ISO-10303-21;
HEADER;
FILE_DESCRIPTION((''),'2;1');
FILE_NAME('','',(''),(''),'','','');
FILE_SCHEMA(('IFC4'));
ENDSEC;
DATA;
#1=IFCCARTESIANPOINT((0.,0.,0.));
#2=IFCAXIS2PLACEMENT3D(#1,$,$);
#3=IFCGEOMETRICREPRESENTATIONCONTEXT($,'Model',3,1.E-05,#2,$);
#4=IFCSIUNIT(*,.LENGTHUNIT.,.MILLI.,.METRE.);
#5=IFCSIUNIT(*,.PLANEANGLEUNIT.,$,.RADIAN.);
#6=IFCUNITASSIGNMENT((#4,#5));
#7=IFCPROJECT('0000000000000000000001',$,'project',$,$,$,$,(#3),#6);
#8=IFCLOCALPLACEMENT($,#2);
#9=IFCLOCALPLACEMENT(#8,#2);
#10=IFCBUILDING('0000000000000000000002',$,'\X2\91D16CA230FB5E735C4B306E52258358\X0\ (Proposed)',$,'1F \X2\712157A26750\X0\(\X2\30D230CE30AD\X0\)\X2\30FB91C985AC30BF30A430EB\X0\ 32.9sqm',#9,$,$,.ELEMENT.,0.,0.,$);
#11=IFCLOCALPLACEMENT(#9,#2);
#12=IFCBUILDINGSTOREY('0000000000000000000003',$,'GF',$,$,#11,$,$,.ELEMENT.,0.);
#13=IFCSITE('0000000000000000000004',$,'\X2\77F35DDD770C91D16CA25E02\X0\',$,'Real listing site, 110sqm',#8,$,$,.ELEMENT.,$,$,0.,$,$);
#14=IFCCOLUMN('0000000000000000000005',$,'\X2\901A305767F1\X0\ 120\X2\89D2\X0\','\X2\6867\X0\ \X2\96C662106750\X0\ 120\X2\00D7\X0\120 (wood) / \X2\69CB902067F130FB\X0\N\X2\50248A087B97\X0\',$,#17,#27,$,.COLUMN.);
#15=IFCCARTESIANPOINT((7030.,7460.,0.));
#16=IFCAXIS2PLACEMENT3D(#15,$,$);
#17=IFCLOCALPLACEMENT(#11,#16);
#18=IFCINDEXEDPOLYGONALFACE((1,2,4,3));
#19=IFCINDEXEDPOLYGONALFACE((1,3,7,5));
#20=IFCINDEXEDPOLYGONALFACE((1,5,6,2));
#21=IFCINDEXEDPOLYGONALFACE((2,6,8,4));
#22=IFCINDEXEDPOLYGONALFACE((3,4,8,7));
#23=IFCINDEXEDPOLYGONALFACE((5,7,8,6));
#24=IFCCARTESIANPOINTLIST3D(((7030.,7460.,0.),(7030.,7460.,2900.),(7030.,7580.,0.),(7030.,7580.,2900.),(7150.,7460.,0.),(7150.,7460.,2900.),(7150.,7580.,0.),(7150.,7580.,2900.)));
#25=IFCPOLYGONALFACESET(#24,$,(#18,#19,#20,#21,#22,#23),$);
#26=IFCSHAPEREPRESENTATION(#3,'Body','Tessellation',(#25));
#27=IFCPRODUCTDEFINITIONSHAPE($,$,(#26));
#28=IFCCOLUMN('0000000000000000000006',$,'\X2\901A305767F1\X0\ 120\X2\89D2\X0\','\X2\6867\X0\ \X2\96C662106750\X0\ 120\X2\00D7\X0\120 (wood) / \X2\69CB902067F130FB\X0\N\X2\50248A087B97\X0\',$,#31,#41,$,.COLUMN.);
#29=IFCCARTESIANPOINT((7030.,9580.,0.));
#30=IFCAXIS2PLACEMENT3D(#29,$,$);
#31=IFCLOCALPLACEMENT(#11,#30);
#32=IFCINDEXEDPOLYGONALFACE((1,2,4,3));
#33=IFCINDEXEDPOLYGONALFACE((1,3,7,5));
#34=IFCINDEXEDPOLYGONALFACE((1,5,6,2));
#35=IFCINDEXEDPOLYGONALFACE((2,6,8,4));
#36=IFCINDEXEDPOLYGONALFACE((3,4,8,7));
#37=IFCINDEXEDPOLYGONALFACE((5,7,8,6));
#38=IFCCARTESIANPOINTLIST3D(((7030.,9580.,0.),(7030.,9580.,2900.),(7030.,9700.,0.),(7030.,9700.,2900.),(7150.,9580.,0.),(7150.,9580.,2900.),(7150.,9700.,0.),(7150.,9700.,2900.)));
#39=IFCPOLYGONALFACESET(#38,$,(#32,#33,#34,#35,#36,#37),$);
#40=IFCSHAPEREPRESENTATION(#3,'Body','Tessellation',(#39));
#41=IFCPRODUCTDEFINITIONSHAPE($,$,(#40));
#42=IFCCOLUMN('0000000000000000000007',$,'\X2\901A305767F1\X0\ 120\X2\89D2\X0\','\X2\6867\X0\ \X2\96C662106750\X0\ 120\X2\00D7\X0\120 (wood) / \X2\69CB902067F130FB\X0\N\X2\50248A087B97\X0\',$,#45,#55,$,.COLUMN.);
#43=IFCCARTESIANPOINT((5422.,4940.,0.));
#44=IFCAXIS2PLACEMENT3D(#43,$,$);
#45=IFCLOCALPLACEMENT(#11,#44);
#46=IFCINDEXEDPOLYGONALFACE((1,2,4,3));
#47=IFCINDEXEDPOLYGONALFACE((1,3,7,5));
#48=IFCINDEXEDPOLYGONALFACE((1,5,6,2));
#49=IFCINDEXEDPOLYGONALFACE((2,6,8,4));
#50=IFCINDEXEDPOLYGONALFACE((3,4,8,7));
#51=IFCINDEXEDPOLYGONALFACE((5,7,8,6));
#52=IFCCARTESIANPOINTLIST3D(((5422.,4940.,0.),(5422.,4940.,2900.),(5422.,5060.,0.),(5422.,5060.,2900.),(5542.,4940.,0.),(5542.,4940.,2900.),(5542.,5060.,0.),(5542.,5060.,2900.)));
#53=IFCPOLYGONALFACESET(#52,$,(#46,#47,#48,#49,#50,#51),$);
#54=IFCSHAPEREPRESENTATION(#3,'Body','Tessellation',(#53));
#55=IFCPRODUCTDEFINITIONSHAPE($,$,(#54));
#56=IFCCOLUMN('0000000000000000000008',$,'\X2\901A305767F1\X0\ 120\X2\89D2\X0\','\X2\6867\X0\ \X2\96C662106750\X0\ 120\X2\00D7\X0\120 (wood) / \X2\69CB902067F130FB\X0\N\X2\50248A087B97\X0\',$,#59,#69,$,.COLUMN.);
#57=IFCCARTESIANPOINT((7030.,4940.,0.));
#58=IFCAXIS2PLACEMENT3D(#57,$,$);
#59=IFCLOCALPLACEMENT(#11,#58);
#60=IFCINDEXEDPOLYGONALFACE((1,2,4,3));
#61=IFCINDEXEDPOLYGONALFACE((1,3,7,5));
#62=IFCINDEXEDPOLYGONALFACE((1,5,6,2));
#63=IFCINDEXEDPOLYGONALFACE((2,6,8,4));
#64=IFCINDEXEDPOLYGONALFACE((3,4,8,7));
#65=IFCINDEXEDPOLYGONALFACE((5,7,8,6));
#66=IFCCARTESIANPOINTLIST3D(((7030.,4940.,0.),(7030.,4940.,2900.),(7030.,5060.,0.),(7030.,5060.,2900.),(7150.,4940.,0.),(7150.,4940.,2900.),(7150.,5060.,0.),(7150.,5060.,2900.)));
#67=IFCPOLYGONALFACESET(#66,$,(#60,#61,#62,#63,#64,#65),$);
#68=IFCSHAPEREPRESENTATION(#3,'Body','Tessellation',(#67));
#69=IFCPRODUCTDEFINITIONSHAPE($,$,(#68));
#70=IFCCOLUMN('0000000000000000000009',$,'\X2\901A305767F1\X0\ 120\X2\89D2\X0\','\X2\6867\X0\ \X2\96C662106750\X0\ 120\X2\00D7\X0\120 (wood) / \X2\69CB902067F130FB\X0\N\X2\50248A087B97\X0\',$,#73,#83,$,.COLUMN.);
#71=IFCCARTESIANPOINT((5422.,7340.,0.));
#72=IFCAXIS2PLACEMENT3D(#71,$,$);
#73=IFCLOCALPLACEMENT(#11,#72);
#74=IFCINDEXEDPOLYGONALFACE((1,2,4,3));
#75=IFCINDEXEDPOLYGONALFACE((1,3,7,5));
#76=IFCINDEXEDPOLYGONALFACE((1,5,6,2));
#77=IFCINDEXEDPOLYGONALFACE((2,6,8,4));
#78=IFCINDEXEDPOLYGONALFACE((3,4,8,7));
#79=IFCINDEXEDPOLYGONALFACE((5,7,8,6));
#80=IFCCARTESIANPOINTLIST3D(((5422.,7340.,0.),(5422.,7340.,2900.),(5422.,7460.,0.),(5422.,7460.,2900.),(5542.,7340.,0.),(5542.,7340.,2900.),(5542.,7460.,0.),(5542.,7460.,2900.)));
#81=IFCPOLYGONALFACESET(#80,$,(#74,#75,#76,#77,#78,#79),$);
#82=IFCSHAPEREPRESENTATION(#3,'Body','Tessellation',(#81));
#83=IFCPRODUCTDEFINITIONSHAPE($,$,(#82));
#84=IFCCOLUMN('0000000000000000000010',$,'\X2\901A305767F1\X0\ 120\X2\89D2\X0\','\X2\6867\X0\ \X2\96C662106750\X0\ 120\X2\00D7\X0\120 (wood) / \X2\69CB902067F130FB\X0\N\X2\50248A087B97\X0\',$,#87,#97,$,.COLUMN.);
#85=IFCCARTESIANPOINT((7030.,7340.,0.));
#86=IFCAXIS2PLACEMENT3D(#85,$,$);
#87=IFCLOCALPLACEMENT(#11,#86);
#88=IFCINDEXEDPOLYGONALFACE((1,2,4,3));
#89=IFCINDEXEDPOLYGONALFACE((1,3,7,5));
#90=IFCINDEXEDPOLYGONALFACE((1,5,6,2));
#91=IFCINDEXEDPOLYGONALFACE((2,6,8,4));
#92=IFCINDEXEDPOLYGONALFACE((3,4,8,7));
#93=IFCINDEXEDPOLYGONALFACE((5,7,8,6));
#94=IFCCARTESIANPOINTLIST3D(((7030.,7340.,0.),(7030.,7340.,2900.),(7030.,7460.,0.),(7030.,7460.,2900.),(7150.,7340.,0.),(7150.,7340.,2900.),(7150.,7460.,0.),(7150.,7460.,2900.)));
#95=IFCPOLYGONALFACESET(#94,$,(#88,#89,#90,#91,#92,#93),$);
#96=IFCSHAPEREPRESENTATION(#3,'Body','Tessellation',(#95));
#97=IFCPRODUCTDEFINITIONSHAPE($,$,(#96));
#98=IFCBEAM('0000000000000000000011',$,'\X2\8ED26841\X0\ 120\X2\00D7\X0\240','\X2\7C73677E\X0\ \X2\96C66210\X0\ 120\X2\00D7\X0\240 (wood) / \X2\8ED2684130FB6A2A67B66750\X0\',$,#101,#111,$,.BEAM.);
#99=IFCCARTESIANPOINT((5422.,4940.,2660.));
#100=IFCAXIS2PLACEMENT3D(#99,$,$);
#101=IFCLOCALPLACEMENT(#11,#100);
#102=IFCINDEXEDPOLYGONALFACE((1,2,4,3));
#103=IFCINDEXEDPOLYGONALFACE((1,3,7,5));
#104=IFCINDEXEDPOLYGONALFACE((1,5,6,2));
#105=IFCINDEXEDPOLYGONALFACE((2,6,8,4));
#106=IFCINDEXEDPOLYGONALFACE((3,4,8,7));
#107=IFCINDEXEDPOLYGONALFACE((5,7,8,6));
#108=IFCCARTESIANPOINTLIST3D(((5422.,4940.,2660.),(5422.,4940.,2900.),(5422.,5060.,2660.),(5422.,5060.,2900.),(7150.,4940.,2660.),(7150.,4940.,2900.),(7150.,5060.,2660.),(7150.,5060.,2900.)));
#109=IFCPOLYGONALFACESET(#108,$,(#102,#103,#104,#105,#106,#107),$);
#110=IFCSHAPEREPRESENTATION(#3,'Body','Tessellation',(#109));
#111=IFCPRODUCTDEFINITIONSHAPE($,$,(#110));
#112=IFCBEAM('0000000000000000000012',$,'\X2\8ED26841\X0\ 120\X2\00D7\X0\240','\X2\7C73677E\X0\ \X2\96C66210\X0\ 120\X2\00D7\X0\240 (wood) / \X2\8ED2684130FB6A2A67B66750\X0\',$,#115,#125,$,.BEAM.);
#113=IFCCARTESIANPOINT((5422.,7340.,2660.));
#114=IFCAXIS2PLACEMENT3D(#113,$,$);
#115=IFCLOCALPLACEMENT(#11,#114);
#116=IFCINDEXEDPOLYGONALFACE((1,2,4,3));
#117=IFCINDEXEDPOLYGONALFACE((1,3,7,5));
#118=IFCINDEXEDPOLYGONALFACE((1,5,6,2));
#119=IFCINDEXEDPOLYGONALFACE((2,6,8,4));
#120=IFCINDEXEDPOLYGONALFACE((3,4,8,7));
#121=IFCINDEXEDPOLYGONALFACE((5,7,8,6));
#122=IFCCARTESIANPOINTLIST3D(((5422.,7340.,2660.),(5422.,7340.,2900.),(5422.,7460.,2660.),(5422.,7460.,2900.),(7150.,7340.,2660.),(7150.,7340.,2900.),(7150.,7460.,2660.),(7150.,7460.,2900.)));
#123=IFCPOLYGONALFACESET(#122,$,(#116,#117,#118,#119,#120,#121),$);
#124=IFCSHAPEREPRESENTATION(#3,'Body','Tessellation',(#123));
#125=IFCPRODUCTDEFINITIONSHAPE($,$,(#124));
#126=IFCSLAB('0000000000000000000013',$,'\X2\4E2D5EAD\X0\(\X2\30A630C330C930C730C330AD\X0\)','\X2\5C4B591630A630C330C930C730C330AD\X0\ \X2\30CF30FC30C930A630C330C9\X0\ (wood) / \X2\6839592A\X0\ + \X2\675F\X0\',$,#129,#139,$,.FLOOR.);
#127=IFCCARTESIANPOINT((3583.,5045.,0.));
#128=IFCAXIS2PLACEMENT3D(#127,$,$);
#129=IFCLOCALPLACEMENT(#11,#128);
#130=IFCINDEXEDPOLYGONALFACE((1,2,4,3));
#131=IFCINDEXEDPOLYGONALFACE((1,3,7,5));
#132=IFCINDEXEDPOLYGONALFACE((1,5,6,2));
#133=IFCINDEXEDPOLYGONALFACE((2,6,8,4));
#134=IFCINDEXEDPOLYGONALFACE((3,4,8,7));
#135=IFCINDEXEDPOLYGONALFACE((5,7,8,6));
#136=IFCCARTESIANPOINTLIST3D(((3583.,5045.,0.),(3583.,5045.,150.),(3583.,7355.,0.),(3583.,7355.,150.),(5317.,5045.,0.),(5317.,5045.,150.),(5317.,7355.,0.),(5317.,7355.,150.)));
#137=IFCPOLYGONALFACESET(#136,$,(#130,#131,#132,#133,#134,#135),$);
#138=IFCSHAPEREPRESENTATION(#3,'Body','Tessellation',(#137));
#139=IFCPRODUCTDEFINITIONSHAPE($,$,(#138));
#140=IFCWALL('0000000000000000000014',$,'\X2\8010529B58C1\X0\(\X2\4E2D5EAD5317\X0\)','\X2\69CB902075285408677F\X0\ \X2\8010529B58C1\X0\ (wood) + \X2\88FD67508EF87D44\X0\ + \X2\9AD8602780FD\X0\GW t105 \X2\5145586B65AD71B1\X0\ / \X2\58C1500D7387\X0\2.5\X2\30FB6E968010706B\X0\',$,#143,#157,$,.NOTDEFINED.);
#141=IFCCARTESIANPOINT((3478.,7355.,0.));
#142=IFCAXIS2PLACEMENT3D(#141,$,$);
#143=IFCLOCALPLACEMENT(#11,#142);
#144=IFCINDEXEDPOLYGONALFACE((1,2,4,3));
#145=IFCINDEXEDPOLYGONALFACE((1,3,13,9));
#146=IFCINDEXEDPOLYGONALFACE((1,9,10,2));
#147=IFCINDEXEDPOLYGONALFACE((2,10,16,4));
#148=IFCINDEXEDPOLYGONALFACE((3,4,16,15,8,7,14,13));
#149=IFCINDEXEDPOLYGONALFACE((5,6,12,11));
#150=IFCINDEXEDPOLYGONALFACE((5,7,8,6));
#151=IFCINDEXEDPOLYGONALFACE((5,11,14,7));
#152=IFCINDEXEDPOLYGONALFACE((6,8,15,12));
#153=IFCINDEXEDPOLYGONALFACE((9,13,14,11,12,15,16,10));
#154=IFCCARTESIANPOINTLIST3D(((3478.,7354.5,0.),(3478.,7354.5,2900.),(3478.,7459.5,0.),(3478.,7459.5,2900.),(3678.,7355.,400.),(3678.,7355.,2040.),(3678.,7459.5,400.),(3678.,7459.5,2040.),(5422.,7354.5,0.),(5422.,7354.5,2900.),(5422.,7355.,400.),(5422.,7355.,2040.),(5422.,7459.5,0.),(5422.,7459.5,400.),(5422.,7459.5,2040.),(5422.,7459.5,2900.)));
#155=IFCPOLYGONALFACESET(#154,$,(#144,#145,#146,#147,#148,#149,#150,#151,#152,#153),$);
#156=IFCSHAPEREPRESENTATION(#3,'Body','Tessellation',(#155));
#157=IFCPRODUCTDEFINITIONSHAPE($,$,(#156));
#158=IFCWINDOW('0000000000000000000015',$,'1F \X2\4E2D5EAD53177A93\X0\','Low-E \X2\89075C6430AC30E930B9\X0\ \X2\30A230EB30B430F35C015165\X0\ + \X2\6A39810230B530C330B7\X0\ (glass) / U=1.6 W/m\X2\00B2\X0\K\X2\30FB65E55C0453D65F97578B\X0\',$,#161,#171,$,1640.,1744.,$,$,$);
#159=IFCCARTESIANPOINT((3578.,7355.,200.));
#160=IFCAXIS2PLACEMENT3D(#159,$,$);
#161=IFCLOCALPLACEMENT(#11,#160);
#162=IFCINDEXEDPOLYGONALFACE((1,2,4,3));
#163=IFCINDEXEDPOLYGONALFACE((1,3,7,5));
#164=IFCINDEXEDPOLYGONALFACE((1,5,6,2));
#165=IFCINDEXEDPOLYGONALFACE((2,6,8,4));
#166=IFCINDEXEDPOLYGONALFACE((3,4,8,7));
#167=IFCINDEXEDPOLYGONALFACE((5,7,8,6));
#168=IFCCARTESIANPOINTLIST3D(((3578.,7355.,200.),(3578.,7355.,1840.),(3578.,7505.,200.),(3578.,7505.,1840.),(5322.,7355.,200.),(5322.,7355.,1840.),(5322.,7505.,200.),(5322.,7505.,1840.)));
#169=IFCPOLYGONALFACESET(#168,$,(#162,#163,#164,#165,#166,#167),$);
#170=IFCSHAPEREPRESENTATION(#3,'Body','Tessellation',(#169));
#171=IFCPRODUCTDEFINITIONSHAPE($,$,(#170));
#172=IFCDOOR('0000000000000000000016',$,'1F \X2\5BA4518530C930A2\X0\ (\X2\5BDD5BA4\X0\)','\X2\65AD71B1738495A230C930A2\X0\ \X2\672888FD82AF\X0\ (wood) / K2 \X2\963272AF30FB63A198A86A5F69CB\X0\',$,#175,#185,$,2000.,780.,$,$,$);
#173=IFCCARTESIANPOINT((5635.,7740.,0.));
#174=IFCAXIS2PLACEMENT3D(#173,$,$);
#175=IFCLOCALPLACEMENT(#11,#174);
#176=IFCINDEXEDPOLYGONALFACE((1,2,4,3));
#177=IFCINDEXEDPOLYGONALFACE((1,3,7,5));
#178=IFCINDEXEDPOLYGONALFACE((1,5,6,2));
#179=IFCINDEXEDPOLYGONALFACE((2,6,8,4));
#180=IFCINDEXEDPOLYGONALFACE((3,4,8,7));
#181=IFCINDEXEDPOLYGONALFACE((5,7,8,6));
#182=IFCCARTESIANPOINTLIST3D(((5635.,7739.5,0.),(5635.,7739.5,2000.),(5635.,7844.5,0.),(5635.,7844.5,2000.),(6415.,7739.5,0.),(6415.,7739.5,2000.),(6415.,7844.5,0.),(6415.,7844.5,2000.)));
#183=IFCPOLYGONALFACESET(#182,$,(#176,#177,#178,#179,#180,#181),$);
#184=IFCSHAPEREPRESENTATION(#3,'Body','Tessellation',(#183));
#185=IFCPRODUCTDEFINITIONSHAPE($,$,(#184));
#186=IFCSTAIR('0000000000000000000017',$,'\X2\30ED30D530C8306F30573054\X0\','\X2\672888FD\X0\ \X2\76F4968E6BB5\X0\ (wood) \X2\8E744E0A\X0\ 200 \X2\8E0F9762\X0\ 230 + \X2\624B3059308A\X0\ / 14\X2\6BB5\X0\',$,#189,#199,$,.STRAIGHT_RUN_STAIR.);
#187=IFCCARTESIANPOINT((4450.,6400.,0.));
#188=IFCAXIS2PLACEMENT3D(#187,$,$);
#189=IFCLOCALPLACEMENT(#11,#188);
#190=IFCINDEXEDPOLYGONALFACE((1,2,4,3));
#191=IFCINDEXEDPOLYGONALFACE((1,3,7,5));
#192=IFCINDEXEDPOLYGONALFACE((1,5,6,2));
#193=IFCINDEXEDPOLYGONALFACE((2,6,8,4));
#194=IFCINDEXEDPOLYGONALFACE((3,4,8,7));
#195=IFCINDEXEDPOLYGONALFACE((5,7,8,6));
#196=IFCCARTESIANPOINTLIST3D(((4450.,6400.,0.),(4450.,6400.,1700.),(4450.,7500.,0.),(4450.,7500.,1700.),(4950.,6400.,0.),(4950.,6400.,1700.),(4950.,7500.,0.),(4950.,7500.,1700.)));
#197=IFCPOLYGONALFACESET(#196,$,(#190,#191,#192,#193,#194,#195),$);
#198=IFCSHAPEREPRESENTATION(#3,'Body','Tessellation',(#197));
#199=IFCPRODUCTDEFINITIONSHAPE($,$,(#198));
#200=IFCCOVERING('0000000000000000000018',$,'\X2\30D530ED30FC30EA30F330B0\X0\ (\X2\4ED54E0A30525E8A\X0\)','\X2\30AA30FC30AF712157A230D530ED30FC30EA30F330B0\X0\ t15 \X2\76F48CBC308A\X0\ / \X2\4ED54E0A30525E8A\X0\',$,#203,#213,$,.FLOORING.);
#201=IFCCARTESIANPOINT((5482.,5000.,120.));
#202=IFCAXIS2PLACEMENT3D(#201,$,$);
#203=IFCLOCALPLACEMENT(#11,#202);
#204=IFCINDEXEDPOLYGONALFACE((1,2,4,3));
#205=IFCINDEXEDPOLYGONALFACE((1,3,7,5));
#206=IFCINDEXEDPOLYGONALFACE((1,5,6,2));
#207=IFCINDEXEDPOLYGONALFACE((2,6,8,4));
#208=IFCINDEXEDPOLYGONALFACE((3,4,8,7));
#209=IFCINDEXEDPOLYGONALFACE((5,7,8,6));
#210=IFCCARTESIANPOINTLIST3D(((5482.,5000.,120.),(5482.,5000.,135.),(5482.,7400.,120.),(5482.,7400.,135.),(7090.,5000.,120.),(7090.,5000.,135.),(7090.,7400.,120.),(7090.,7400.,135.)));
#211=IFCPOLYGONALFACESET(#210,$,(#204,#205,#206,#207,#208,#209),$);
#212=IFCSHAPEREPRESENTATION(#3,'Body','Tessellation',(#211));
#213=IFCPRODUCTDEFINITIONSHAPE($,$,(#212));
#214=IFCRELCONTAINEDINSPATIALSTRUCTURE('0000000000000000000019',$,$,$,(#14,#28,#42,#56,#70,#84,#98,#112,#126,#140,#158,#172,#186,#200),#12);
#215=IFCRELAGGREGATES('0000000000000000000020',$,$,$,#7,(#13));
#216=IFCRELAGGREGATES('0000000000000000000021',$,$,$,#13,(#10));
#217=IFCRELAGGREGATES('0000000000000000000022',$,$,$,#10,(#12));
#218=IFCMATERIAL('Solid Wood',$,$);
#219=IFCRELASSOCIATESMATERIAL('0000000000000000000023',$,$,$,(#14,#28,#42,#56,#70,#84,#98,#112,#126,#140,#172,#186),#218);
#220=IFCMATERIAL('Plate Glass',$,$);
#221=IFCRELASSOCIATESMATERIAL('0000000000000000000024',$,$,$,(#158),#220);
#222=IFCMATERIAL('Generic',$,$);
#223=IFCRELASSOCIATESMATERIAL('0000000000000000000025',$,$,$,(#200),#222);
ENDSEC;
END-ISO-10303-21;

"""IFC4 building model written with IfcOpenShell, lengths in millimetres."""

from ifc_helpers import new_model, si_unit, frame, frame_2d, origin, place, context, project, spatial, rectangle, extrude, material, element, fill, save


model = new_model("IFC4")

# Units and contexts
model_context = context("Model", 3, precision=1e-05, world=origin())
ifc_project = project(units=[si_unit("LENGTHUNIT", "METRE", prefix="MILLI"), si_unit("PLANEANGLEUNIT", "RADIAN")], contexts=[model_context])

# Site, building, storey
site_placement = place(None, origin())
site = spatial("IfcSite", under=ifc_project, at=site_placement, Name="石川県金沢市", ObjectType="Real listing site, 110sqm", CompositionType="ELEMENT", RefElevation=0.0)
building_placement = place(site_placement, origin())
building = spatial("IfcBuilding", under=site, at=building_placement, Name="金沢・平屋の別荘 (Proposed)", ObjectType="1F 無垢材(ヒノキ)・釉薬タイル 32.9sqm", CompositionType="ELEMENT", ElevationOfRefHeight=0.0, ElevationOfTerrain=0.0)
storey_placement = place(building_placement, origin())
storey = spatial("IfcBuildingStorey", under=building, at=storey_placement, Name="GF", CompositionType="ELEMENT", Elevation=0.0)

# Columns
ifc_material_1 = material(Name="Solid Wood")
column_1_placement = place(storey_placement, frame((7030.0, 7460.0, 0.0)))
element("IfcColumn", 1, at=column_1_placement, inside=storey, material=ifc_material_1, Name="通し柱 120角", Description="桧 集成材 120×120 (wood) / 構造柱・N値計算", PredefinedType="COLUMN", context=model_context, shape_type="SweptSolid", body=[
    extrude(rectangle(XDim=120.0, YDim=120.0, at=frame_2d((60.0, 60.0))), frame((7030.0, 7460.0, 0.0)), (0.0, 0.0, 1.0), 2900.0),
])
column_2_placement = place(storey_placement, frame((7030.0, 9580.0, 0.0)))
element("IfcColumn", 2, at=column_2_placement, inside=storey, material=ifc_material_1, Name="通し柱 120角", Description="桧 集成材 120×120 (wood) / 構造柱・N値計算", PredefinedType="COLUMN", context=model_context, shape_type="SweptSolid", body=[
    extrude(rectangle(XDim=120.0, YDim=120.0, at=frame_2d((60.0, 60.0))), frame((7030.0, 9580.0, 0.0)), (0.0, 0.0, 1.0), 2900.0),
])
column_3_placement = place(storey_placement, frame((5422.0, 4940.0, 0.0)))
element("IfcColumn", 3, at=column_3_placement, inside=storey, material=ifc_material_1, Name="通し柱 120角", Description="桧 集成材 120×120 (wood) / 構造柱・N値計算", PredefinedType="COLUMN", context=model_context, shape_type="SweptSolid", body=[
    extrude(rectangle(XDim=120.0, YDim=120.0, at=frame_2d((60.0, 60.0))), frame((5422.0, 4940.0, 0.0)), (0.0, 0.0, 1.0), 2900.0),
])
column_4_placement = place(storey_placement, frame((7030.0, 4940.0, 0.0)))
element("IfcColumn", 4, at=column_4_placement, inside=storey, material=ifc_material_1, Name="通し柱 120角", Description="桧 集成材 120×120 (wood) / 構造柱・N値計算", PredefinedType="COLUMN", context=model_context, shape_type="SweptSolid", body=[
    extrude(rectangle(XDim=120.0, YDim=120.0, at=frame_2d((60.0, 60.0))), frame((7030.0, 4940.0, 0.0)), (0.0, 0.0, 1.0), 2900.0),
])
column_5_placement = place(storey_placement, frame((5422.0, 7340.0, 0.0)))
element("IfcColumn", 5, at=column_5_placement, inside=storey, material=ifc_material_1, Name="通し柱 120角", Description="桧 集成材 120×120 (wood) / 構造柱・N値計算", PredefinedType="COLUMN", context=model_context, shape_type="SweptSolid", body=[
    extrude(rectangle(XDim=120.0, YDim=120.0, at=frame_2d((60.0, 60.0))), frame((5422.0, 7340.0, 0.0)), (0.0, 0.0, 1.0), 2900.0),
])
column_6_placement = place(storey_placement, frame((7030.0, 7340.0, 0.0)))
element("IfcColumn", 6, at=column_6_placement, inside=storey, material=ifc_material_1, Name="通し柱 120角", Description="桧 集成材 120×120 (wood) / 構造柱・N値計算", PredefinedType="COLUMN", context=model_context, shape_type="SweptSolid", body=[
    extrude(rectangle(XDim=120.0, YDim=120.0, at=frame_2d((60.0, 60.0))), frame((7030.0, 7340.0, 0.0)), (0.0, 0.0, 1.0), 2900.0),
])

# Beams
beam_1_placement = place(storey_placement, frame((5422.0, 4940.0, 2660.0)))
element("IfcBeam", 7, at=beam_1_placement, inside=storey, material=ifc_material_1, Name="軒桁 120×240", Description="米松 集成 120×240 (wood) / 軒桁・横架材", PredefinedType="BEAM", context=model_context, shape_type="SweptSolid", body=[
    extrude(rectangle(XDim=1728.0, YDim=120.0, at=frame_2d((864.0, 60.0))), frame((5422.0, 4940.0, 2660.0)), (0.0, 0.0, 1.0), 240.0),
])
beam_2_placement = place(storey_placement, frame((5422.0, 7340.0, 2660.0)))
element("IfcBeam", 8, at=beam_2_placement, inside=storey, material=ifc_material_1, Name="軒桁 120×240", Description="米松 集成 120×240 (wood) / 軒桁・横架材", PredefinedType="BEAM", context=model_context, shape_type="SweptSolid", body=[
    extrude(rectangle(XDim=1728.0, YDim=120.0, at=frame_2d((864.0, 60.0))), frame((5422.0, 7340.0, 2660.0)), (0.0, 0.0, 1.0), 240.0),
])

# Slab
slab_placement = place(storey_placement, frame((3583.0, 5045.0, 0.0)))
element("IfcSlab", 9, at=slab_placement, inside=storey, material=ifc_material_1, Name="中庭(ウッドデッキ)", Description="屋外ウッドデッキ ハードウッド (wood) / 根太 + 束", PredefinedType="FLOOR", context=model_context, shape_type="SweptSolid", body=[
    extrude(rectangle(XDim=1734.0, YDim=2310.0, at=frame_2d((867.0, 1155.0))), frame((3583.0, 5045.0, 0.0)), (0.0, 0.0, 1.0), 150.0),
])

# Wall, opening, window
wall_1_placement = place(storey_placement, frame((3478.0, 7355.0, 0.0)))
wall_1 = element("IfcWall", 10, at=wall_1_placement, inside=storey, material=ifc_material_1, Name="耐力壁(中庭北)", Description="構造用合板 耐力壁 (wood) + 製材軸組 + 高性能GW t105 充填断熱 / 壁倍率2.5・準耐火", PredefinedType="NOTDEFINED", context=model_context, shape_type="SweptSolid", body=[
    extrude(rectangle(XDim=1944.0, YDim=105.0, at=frame_2d((972.0, 52.0))), frame((3478.0, 7355.0, 0.0)), (0.0, 0.0, 1.0), 2900.0),
])
opening_placement = place(storey_placement, frame((3578.0, 7355.0, 200.0)))
opening = element("IfcOpeningElement", 11, at=opening_placement, cuts=wall_1, PredefinedType="NOTDEFINED", context=model_context, shape_type="SweptSolid", body=[
    extrude(rectangle(XDim=1744.0, YDim=150.0, at=frame_2d((872.0, 75.0))), frame((3578.0, 7355.0, 200.0)), (0.0, 0.0, 1.0), 1640.0),
])
ifc_material_2 = material(Name="Plate Glass")
window_placement = place(storey_placement, frame((3578.0, 7355.0, 200.0)))
window = element("IfcWindow", 12, at=window_placement, inside=storey, material=ifc_material_2, Name="1F 中庭北窓", Description="Low-E 複層ガラス アルゴン封入 + 樹脂サッシ (glass) / U=1.6 W/m²K・日射取得型", OverallHeight=1640.0, OverallWidth=1744.0, context=model_context, shape_type="SweptSolid", body=[
    extrude(rectangle(XDim=1744.0, YDim=150.0, at=frame_2d((872.0, 75.0))), frame((3578.0, 7355.0, 200.0)), (0.0, 0.0, 1.0), 1640.0),
])
fill(opening, window)

# Door
door_placement = place(storey_placement, frame((5635.0, 7740.0, 0.0)))
element("IfcDoor", 13, at=door_placement, inside=storey, material=ifc_material_1, Name="1F 室内ドア (寝室)", Description="断熱玄関ドア 木製芯 (wood) / K2 防犯・採風機構", OverallHeight=2000.0, OverallWidth=780.0, context=model_context, shape_type="SweptSolid", body=[
    extrude(rectangle(XDim=780.0, YDim=105.0, at=frame_2d((390.0, 52.0))), frame((5635.0, 7740.0, 0.0)), (0.0, 0.0, 1.0), 2000.0),
])

# Stair
stair_placement = place(storey_placement, frame((4450.0, 6400.0, 0.0)))
element("IfcStair", 14, at=stair_placement, inside=storey, material=ifc_material_1, Name="ロフトはしご", Description="木製 直階段 (wood) 蹴上 200 踏面 230 + 手すり / 14段", PredefinedType="STRAIGHT_RUN_STAIR", context=model_context, shape_type="SweptSolid", body=[
    extrude(rectangle(XDim=500.0, YDim=1100.0, at=frame_2d((250.0, 550.0))), frame((4450.0, 6400.0, 0.0)), (0.0, 0.0, 1.0), 1700.0),
])

# Covering
ifc_material_3 = material(Name="Generic")
covering_placement = place(storey_placement, frame((5482.0, 5000.0, 120.0)))
element("IfcCovering", 15, at=covering_placement, inside=storey, material=ifc_material_3, Name="フローリング (仕上げ床)", Description="オーク無垢フローリング t15 直貼り / 仕上げ床", PredefinedType="FLOORING", context=model_context, shape_type="SweptSolid", body=[
    extrude(rectangle(XDim=1608.0, YDim=2400.0, at=frame_2d((804.0, 1200.0))), frame((5482.0, 5000.0, 120.0)), (0.0, 0.0, 1.0), 15.0),
])

save(model, "model.ifc")
